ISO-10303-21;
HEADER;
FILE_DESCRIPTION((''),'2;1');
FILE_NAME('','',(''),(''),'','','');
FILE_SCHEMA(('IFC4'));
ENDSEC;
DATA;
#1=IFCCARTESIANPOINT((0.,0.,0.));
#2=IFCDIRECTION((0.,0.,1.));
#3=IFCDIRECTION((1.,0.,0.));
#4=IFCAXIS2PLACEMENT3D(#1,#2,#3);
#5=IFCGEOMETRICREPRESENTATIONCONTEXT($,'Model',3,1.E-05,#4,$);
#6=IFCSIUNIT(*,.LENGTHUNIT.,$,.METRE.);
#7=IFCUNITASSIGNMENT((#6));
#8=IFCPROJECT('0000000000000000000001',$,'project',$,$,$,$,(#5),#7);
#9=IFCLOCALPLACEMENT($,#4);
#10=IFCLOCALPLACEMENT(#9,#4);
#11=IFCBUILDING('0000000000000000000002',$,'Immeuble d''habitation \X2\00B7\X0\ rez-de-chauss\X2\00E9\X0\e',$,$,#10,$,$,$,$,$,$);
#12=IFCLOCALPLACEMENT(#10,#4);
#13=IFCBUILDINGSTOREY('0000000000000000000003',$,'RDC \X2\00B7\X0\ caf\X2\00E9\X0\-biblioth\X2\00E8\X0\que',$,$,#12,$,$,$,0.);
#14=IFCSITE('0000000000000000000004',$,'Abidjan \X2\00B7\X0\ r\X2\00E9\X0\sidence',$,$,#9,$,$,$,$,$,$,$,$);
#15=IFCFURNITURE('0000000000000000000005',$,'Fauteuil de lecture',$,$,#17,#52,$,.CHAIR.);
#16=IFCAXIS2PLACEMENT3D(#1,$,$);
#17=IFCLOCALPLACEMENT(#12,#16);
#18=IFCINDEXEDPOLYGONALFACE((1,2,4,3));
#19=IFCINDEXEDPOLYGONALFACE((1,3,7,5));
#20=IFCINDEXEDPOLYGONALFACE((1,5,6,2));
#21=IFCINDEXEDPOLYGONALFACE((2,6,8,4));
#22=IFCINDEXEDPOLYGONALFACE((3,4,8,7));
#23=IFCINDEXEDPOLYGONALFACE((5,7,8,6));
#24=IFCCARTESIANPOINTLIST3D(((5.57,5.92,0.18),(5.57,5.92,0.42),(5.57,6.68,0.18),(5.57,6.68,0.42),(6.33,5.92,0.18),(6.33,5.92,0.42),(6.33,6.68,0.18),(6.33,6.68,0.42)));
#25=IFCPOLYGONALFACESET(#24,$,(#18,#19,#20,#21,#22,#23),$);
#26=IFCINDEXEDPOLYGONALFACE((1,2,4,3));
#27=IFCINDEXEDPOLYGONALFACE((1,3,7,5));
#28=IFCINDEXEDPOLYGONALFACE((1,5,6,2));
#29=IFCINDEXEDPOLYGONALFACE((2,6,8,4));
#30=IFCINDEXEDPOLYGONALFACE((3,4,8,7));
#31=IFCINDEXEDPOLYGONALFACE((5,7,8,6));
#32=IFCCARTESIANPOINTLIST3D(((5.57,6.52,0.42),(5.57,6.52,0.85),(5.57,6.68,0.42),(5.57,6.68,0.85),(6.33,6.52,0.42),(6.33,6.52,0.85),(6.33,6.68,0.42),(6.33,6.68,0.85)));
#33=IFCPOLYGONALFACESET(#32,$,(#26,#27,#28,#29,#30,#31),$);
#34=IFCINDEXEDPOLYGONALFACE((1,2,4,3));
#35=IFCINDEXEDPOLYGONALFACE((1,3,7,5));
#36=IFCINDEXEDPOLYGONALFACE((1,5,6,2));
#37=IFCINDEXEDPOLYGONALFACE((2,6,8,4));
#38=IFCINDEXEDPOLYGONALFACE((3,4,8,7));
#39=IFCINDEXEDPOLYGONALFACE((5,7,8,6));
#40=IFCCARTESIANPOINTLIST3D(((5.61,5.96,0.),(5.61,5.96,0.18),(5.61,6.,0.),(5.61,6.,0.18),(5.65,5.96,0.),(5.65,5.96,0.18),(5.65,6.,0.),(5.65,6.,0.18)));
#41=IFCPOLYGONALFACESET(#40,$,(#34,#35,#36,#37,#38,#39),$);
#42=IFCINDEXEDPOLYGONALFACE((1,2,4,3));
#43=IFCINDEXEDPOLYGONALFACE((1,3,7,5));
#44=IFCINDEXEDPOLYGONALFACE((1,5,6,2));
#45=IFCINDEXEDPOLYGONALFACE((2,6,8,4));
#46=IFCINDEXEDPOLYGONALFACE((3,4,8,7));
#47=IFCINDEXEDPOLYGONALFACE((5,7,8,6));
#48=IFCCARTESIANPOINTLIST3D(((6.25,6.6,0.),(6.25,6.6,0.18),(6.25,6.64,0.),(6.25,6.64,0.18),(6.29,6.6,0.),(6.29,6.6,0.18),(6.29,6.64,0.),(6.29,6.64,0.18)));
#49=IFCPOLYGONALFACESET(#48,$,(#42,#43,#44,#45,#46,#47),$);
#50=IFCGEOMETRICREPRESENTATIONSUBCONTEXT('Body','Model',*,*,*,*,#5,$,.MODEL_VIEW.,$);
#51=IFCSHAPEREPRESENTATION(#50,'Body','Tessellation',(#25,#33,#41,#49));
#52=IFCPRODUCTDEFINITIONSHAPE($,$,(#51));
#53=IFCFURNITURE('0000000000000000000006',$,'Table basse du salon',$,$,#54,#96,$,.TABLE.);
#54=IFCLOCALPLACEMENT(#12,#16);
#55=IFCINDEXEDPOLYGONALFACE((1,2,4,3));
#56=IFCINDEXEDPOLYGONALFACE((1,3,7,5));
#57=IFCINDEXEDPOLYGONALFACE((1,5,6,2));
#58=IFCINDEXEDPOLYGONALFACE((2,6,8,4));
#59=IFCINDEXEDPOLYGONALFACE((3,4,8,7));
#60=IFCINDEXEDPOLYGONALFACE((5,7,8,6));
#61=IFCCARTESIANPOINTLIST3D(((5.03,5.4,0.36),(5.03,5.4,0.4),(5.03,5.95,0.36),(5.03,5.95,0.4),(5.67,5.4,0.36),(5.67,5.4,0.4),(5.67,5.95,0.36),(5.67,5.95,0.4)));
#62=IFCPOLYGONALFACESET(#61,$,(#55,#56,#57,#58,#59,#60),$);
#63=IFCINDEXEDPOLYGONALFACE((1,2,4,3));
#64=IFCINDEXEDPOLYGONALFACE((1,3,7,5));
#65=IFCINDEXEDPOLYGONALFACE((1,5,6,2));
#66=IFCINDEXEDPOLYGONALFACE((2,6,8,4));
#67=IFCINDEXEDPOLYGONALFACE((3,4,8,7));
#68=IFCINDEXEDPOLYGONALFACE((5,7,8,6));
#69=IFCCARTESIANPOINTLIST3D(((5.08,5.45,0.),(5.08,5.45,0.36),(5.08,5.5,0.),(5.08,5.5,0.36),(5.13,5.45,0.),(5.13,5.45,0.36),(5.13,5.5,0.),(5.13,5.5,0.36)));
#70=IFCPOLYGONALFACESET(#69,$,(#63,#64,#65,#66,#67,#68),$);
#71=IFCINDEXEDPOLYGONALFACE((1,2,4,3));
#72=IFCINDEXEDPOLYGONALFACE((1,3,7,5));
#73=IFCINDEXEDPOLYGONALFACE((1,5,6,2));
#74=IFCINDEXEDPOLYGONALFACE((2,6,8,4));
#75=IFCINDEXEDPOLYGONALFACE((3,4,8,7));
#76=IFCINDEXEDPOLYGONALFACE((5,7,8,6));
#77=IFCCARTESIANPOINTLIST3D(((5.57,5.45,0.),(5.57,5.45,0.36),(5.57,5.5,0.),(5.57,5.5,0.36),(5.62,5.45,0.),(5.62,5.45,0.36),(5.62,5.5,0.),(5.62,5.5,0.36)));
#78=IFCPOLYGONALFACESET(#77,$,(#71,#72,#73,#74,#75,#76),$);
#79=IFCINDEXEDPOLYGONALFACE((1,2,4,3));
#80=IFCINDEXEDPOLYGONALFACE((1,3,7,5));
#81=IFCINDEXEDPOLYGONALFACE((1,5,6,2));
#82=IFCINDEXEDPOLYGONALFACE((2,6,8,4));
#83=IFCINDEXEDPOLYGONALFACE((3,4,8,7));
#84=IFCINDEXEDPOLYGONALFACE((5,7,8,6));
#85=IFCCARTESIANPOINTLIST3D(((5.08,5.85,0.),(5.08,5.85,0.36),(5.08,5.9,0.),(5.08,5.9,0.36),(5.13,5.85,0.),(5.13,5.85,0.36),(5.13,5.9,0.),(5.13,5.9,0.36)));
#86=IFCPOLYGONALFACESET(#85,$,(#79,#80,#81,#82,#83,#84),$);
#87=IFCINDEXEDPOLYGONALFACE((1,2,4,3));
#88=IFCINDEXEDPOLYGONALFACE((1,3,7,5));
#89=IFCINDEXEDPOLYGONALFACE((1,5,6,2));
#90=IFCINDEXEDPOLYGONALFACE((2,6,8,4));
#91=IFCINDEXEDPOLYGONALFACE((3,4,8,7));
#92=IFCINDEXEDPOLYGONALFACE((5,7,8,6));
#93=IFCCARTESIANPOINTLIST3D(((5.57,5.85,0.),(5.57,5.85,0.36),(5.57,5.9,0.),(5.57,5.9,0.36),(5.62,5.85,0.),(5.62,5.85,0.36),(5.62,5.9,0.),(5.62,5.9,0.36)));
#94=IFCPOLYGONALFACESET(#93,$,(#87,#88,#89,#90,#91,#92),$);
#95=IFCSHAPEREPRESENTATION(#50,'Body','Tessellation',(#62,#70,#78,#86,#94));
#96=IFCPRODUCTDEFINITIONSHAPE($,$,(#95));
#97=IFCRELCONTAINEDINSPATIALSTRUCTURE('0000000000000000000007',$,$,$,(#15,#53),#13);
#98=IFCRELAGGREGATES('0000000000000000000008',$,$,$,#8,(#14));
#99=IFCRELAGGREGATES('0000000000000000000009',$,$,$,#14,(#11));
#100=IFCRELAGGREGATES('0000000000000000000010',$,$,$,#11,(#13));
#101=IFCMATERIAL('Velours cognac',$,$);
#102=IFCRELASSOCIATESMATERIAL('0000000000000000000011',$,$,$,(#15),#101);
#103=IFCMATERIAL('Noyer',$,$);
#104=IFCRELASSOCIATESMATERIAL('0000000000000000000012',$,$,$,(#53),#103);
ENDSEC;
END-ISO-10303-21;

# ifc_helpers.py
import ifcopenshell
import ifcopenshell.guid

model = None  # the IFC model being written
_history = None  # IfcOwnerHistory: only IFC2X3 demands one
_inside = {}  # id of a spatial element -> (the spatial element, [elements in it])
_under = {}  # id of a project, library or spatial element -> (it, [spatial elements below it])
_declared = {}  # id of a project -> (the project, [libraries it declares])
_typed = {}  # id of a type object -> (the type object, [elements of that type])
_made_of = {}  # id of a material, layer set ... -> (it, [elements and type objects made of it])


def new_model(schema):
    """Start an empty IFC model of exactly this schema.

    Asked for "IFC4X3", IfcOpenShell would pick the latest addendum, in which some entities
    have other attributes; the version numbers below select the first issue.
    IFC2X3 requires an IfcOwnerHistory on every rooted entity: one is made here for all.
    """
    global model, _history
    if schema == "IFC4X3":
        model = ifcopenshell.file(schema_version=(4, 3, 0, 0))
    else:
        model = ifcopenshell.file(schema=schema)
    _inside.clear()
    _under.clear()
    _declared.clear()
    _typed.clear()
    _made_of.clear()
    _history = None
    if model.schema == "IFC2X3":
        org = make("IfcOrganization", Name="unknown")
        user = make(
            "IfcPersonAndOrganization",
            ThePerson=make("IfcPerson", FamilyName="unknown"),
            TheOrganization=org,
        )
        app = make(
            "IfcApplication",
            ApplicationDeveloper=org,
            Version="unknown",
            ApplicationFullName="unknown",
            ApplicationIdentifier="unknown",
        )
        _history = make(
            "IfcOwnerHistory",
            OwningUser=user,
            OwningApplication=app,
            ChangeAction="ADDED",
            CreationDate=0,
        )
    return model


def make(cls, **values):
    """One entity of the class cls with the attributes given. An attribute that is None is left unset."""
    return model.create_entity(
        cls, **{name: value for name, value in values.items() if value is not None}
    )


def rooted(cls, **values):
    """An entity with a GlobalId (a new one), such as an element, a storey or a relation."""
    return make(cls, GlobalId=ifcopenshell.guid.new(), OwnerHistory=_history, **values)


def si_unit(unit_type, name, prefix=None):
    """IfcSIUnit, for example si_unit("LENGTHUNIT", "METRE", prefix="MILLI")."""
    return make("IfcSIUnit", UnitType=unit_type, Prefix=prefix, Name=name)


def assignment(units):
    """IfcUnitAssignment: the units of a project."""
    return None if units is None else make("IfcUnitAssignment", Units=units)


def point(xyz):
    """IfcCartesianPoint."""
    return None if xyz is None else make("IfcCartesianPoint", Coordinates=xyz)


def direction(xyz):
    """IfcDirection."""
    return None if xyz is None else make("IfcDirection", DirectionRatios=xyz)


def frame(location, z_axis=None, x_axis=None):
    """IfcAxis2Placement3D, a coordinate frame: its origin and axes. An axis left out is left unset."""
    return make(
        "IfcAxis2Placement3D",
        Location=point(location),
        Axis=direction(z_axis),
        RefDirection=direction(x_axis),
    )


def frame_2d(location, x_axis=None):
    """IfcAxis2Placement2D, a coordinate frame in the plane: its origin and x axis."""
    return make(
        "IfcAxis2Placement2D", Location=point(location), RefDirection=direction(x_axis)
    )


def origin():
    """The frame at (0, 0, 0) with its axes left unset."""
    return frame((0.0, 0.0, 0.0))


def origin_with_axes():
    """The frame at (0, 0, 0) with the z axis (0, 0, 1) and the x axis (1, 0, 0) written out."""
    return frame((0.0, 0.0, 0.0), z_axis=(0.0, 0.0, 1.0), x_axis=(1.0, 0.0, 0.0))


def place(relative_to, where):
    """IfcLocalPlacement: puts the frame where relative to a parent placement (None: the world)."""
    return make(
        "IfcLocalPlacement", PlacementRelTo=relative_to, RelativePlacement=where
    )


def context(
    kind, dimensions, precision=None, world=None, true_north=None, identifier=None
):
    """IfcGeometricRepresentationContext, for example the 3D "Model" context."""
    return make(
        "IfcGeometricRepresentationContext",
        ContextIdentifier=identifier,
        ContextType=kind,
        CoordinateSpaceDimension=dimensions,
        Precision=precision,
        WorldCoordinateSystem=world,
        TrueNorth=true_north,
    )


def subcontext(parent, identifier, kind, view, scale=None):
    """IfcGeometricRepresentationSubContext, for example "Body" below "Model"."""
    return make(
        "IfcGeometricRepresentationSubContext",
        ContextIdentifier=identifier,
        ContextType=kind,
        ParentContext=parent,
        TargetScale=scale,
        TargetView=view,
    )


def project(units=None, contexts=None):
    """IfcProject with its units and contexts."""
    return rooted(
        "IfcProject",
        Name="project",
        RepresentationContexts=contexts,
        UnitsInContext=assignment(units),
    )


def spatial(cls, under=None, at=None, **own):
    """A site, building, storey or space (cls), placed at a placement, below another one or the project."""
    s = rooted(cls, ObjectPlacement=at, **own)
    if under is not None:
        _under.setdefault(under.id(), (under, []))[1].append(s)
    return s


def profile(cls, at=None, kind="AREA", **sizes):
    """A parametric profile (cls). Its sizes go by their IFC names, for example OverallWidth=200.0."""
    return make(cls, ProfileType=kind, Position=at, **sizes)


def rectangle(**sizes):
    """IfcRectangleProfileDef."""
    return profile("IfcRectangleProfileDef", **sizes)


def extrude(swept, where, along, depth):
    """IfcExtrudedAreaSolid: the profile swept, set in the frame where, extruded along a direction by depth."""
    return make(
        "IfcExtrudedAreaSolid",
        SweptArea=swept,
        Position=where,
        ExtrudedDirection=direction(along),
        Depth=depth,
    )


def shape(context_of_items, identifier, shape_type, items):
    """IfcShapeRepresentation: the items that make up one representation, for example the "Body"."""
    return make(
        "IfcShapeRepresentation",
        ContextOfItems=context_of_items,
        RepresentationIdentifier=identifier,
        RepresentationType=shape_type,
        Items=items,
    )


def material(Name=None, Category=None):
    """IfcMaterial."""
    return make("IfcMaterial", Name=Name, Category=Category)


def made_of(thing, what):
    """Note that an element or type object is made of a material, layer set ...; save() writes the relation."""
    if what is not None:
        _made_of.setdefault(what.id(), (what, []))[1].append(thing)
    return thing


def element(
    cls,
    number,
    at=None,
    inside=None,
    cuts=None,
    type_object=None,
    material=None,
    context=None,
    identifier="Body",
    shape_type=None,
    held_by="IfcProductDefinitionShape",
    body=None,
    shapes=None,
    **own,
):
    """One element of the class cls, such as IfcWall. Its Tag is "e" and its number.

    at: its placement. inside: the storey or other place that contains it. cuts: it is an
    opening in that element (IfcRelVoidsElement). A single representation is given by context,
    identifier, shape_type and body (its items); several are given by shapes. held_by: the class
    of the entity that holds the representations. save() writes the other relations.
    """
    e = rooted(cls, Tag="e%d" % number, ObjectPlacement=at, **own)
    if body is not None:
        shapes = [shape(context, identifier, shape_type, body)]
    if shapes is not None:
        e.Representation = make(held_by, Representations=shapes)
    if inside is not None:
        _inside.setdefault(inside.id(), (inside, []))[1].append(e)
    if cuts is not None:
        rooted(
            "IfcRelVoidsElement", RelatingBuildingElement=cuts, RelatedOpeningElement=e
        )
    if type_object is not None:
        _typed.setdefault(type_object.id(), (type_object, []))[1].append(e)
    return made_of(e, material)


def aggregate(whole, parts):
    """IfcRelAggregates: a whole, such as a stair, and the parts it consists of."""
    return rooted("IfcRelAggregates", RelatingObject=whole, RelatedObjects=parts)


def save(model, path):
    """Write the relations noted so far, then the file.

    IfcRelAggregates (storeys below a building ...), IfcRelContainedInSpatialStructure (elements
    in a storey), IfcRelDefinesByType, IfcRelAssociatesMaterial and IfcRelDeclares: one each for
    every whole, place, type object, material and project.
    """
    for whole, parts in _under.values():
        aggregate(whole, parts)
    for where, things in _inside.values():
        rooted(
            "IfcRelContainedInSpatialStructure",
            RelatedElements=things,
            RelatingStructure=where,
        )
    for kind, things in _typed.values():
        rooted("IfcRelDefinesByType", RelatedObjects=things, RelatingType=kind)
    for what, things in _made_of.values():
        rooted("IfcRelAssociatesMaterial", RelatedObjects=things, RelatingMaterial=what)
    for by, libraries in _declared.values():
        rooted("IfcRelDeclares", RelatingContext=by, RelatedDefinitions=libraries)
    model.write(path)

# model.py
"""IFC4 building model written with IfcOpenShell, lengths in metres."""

from ifc_helpers import new_model, si_unit, frame, frame_2d, origin, origin_with_axes, place, context, subcontext, project, spatial, rectangle, extrude, material, element, save


model = new_model("IFC4")

# Units and contexts
model_context = context("Model", 3, precision=1e-05, world=origin_with_axes())
body_context = subcontext(model_context, "Body", "Model", "MODEL_VIEW")
ifc_project = project(units=[si_unit("LENGTHUNIT", "METRE")], contexts=[model_context])

# Site, building, storey
site_placement = place(None, origin_with_axes())
site = spatial("IfcSite", under=ifc_project, at=site_placement, Name="Abidjan · résidence")
building_placement = place(site_placement, origin_with_axes())
building = spatial("IfcBuilding", under=site, at=building_placement, Name="Immeuble d'habitation · rez-de-chaussée")
storey_placement = place(building_placement, origin_with_axes())
storey = spatial("IfcBuildingStorey", under=building, at=storey_placement, Name="RDC · café-bibliothèque", Elevation=0.0)

# Shared definitions
ifc_material_1 = material(Name="Noyer")

# Furniture
ifc_material_2 = material(Name="Velours cognac")
furniture_1_placement = place(storey_placement, origin_with_axes())
element("IfcFurniture", 1, at=furniture_1_placement, inside=storey, material=ifc_material_2, Name="Fauteuil de lecture", PredefinedType="CHAIR", context=body_context, shape_type="SweptSolid", body=[
    extrude(rectangle(XDim=0.76, YDim=0.76, at=frame_2d((5.95, 6.3))), frame((0.0, 0.0, 0.18)), (0.0, 0.0, 1.0), 0.24),
    extrude(rectangle(XDim=0.76, YDim=0.16, at=frame_2d((5.95, 6.6))), frame((0.0, 0.0, 0.42)), (0.0, 0.0, 1.0), 0.43),
    extrude(rectangle(XDim=0.04, YDim=0.04, at=frame_2d((5.63, 5.98))), origin(), (0.0, 0.0, 1.0), 0.18),
    extrude(rectangle(XDim=0.04, YDim=0.04, at=frame_2d((6.27, 6.62))), origin(), (0.0, 0.0, 1.0), 0.18),
])
furniture_2_placement = place(storey_placement, origin_with_axes())
element("IfcFurniture", 2, at=furniture_2_placement, inside=storey, material=ifc_material_1, Name="Table basse du salon", PredefinedType="TABLE", context=body_context, shape_type="SweptSolid", body=[
    extrude(rectangle(XDim=0.64, YDim=0.55, at=frame_2d((5.35, 5.675))), frame((0.0, 0.0, 0.36)), (0.0, 0.0, 1.0), 0.04),
    extrude(rectangle(XDim=0.05, YDim=0.05, at=frame_2d((5.105, 5.475))), origin(), (0.0, 0.0, 1.0), 0.36),
    extrude(rectangle(XDim=0.05, YDim=0.05, at=frame_2d((5.595, 5.475))), origin(), (0.0, 0.0, 1.0), 0.36),
    extrude(rectangle(XDim=0.05, YDim=0.05, at=frame_2d((5.105, 5.875))), origin(), (0.0, 0.0, 1.0), 0.36),
    extrude(rectangle(XDim=0.05, YDim=0.05, at=frame_2d((5.595, 5.875))), origin(), (0.0, 0.0, 1.0), 0.36),
])

save(model, "model.ifc")
